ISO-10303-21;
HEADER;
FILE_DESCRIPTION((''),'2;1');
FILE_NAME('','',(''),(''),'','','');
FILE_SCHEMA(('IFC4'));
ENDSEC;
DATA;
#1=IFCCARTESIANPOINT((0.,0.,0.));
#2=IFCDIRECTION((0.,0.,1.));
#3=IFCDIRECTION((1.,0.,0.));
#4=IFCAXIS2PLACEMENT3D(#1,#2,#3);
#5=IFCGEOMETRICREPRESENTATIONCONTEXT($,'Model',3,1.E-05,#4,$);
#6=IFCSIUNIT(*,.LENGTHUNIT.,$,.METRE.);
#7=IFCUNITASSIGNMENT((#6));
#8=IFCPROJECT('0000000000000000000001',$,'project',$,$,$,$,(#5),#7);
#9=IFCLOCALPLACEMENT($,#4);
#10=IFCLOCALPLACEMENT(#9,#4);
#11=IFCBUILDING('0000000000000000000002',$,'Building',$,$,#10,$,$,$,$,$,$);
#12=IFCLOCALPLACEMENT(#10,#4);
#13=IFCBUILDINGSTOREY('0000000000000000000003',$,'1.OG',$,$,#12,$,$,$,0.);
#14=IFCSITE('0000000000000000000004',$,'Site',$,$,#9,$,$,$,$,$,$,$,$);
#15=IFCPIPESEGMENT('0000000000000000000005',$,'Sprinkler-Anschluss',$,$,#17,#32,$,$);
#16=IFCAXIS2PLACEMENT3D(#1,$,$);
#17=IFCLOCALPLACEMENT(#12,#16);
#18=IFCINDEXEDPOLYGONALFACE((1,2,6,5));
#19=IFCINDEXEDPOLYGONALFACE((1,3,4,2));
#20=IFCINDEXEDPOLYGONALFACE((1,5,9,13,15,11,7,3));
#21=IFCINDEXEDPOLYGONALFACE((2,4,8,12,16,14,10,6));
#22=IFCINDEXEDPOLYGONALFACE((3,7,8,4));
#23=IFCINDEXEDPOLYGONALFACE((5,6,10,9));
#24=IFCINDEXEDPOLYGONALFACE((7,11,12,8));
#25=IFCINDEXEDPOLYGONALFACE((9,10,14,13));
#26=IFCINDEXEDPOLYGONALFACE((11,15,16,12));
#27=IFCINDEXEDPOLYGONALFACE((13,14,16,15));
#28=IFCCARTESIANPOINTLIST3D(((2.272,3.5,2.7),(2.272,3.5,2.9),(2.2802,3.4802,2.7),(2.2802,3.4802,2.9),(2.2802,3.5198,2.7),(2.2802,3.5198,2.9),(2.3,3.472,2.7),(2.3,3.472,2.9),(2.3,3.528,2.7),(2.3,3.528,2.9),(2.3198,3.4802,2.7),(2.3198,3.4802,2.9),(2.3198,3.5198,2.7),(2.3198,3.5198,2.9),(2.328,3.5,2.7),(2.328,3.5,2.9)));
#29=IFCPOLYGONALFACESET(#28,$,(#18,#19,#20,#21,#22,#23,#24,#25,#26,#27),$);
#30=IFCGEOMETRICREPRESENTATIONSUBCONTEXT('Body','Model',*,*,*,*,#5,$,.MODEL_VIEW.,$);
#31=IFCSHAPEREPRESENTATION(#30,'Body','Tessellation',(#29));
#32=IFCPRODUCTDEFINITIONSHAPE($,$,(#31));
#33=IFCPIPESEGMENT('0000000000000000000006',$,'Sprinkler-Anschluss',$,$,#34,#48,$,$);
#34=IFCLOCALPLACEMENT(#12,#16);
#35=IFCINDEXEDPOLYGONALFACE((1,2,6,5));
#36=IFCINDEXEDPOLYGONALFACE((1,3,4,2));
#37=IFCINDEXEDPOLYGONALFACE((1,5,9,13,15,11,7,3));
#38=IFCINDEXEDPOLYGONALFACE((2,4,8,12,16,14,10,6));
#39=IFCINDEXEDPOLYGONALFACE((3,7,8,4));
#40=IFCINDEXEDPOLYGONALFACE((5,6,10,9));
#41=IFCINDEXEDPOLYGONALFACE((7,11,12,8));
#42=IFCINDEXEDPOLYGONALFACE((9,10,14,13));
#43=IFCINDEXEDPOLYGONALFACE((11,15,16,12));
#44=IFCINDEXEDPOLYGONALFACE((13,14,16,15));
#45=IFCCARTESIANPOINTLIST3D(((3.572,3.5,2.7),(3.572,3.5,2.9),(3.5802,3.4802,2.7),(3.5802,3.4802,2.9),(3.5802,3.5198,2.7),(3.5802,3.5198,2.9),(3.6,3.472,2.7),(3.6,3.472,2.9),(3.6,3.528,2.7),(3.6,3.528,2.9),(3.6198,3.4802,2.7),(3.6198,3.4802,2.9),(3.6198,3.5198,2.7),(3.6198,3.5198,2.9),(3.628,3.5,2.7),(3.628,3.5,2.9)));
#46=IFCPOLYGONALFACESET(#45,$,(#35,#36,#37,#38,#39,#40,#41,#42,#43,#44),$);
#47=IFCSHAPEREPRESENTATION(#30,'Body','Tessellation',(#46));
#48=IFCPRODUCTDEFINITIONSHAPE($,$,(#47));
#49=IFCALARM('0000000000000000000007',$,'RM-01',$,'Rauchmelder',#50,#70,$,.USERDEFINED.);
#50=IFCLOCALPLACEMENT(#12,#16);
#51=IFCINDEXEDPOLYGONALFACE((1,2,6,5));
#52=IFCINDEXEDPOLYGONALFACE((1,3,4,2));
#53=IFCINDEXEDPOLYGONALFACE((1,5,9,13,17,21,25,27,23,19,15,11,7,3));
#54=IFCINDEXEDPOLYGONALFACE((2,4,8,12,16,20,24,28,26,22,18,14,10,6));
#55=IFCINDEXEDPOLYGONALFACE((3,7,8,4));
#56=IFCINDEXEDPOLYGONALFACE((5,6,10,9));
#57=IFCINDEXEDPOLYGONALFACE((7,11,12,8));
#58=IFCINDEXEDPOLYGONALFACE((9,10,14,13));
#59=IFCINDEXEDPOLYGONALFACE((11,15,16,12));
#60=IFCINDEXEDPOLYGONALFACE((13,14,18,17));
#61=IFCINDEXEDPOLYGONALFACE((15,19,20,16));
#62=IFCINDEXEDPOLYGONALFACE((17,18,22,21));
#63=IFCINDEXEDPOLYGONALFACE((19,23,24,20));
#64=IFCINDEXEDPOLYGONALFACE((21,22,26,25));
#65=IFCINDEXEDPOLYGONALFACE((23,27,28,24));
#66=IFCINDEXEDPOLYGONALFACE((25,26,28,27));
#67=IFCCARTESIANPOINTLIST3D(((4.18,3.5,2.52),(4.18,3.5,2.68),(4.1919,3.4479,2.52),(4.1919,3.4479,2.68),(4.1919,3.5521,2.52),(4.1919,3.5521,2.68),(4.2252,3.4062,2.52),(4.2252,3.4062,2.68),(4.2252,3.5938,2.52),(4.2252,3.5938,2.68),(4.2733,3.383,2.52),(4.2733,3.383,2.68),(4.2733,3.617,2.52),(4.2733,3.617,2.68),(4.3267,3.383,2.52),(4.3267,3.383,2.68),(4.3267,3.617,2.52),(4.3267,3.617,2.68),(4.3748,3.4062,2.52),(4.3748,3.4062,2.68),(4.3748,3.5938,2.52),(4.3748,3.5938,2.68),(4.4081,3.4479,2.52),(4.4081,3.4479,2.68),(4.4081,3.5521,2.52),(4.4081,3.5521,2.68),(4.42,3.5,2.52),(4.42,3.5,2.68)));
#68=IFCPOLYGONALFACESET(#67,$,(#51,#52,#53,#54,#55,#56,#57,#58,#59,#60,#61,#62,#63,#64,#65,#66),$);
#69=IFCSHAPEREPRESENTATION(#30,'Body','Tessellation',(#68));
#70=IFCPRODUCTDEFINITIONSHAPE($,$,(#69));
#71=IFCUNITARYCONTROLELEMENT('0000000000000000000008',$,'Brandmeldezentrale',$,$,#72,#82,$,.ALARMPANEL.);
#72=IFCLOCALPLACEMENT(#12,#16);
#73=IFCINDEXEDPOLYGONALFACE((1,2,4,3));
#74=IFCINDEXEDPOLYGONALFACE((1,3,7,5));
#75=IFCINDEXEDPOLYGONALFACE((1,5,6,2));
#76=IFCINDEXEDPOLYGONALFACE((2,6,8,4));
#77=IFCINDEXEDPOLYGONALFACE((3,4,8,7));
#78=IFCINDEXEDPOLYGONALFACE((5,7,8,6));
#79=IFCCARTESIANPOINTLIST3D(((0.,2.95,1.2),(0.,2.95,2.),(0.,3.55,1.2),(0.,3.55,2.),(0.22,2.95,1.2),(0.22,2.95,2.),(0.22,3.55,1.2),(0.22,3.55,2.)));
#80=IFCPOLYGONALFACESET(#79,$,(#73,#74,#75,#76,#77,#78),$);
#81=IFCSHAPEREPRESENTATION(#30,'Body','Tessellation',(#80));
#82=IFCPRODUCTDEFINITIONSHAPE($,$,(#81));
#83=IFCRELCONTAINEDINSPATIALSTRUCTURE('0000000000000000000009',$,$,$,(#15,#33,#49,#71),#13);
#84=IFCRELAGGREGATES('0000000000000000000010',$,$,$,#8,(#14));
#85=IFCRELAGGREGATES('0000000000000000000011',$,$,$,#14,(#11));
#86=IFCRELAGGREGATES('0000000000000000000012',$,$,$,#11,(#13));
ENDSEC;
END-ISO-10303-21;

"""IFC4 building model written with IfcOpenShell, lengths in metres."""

from ifc_helpers import new_model, si_unit, frame, origin_with_axes, place, context, subcontext, project, spatial, polyline, outline, extrude, element, save


model = new_model("IFC4")

# Units and contexts
model_context = context("Model", 3, precision=1e-05, world=origin_with_axes())
body_context = subcontext(model_context, "Body", "Model", "MODEL_VIEW")
ifc_project = project(units=[si_unit("LENGTHUNIT", "METRE")], contexts=[model_context])

# Site, building, storey
site_placement = place(None, origin_with_axes())
site = spatial("IfcSite", under=ifc_project, at=site_placement, Name="Site")
building_placement = place(site_placement, origin_with_axes())
building = spatial("IfcBuilding", under=site, at=building_placement, Name="Building")
storey_placement = place(building_placement, origin_with_axes())
storey = spatial("IfcBuildingStorey", under=building, at=storey_placement, Name="1.OG", Elevation=0.0)

# Pipe segments
pipe_segment_1_placement = place(storey_placement, origin_with_axes())
element("IfcPipeSegment", 1, at=pipe_segment_1_placement, inside=storey, Name="Sprinkler-Anschluss", context=body_context, shape_type="SweptSolid", body=[
    extrude(outline(polyline([(0.028, 0.0, 0.0), (0.0198, 0.0198, 0.0), (0.0, 0.028, 0.0), (-0.0198, 0.0198, 0.0), (-0.028, 0.0, 0.0), (-0.0198, -0.0198, 0.0), (0.0, -0.028, 0.0), (0.0198, -0.0198, 0.0), (0.028, 0.0, 0.0)])), frame((2.3, 3.5, 2.7), z_axis=(0.0, 0.0, 1.0), x_axis=(1.0, 0.0, 0.0)), (0.0, 0.0, 1.0), 0.2),
])
pipe_segment_2_placement = place(storey_placement, origin_with_axes())
element("IfcPipeSegment", 2, at=pipe_segment_2_placement, inside=storey, Name="Sprinkler-Anschluss", context=body_context, shape_type="SweptSolid", body=[
    extrude(outline(polyline([(0.028, 0.0, 0.0), (0.0198, 0.0198, 0.0), (0.0, 0.028, 0.0), (-0.0198, 0.0198, 0.0), (-0.028, 0.0, 0.0), (-0.0198, -0.0198, 0.0), (0.0, -0.028, 0.0), (0.0198, -0.0198, 0.0), (0.028, 0.0, 0.0)])), frame((3.6, 3.5, 2.7), z_axis=(0.0, 0.0, 1.0), x_axis=(1.0, 0.0, 0.0)), (0.0, 0.0, 1.0), 0.2),
])

# Alarm
alarm_placement = place(storey_placement, origin_with_axes())
element("IfcAlarm", 3, at=alarm_placement, inside=storey, Name="RM-01", ObjectType="Rauchmelder", PredefinedType="USERDEFINED", context=body_context, shape_type="SweptSolid", body=[
    extrude(outline(polyline([(0.12, 0.0, 0.0), (0.1081, 0.0521, 0.0), (0.0748, 0.0938, 0.0), (0.0267, 0.117, 0.0), (-0.0267, 0.117, 0.0), (-0.0748, 0.0938, 0.0), (-0.1081, 0.0521, 0.0), (-0.12, 0.0, 0.0), (-0.1081, -0.0521, 0.0), (-0.0748, -0.0938, 0.0), (-0.0267, -0.117, 0.0), (0.0267, -0.117, 0.0), (0.0748, -0.0938, 0.0), (0.1081, -0.0521, 0.0), (0.12, 0.0, 0.0)])), frame((4.3, 3.5, 2.52), z_axis=(0.0, 0.0, 1.0), x_axis=(1.0, 0.0, 0.0)), (0.0, 0.0, 1.0), 0.16),
])

# Unitary control element
unitary_control_element_placement = place(storey_placement, origin_with_axes())
element("IfcUnitaryControlElement", 4, at=unitary_control_element_placement, inside=storey, Name="Brandmeldezentrale", PredefinedType="ALARMPANEL", context=body_context, shape_type="SweptSolid", body=[
    extrude(outline(polyline([(0.0, 2.95, 0.0), (0.22, 2.95, 0.0), (0.22, 3.55, 0.0), (0.0, 3.55, 0.0), (0.0, 2.95, 0.0)])), frame((0.0, 0.0, 1.2), z_axis=(0.0, 0.0, 1.0), x_axis=(1.0, 0.0, 0.0)), (0.0, 0.0, 1.0), 0.8),
])

save(model, "model.ifc")
